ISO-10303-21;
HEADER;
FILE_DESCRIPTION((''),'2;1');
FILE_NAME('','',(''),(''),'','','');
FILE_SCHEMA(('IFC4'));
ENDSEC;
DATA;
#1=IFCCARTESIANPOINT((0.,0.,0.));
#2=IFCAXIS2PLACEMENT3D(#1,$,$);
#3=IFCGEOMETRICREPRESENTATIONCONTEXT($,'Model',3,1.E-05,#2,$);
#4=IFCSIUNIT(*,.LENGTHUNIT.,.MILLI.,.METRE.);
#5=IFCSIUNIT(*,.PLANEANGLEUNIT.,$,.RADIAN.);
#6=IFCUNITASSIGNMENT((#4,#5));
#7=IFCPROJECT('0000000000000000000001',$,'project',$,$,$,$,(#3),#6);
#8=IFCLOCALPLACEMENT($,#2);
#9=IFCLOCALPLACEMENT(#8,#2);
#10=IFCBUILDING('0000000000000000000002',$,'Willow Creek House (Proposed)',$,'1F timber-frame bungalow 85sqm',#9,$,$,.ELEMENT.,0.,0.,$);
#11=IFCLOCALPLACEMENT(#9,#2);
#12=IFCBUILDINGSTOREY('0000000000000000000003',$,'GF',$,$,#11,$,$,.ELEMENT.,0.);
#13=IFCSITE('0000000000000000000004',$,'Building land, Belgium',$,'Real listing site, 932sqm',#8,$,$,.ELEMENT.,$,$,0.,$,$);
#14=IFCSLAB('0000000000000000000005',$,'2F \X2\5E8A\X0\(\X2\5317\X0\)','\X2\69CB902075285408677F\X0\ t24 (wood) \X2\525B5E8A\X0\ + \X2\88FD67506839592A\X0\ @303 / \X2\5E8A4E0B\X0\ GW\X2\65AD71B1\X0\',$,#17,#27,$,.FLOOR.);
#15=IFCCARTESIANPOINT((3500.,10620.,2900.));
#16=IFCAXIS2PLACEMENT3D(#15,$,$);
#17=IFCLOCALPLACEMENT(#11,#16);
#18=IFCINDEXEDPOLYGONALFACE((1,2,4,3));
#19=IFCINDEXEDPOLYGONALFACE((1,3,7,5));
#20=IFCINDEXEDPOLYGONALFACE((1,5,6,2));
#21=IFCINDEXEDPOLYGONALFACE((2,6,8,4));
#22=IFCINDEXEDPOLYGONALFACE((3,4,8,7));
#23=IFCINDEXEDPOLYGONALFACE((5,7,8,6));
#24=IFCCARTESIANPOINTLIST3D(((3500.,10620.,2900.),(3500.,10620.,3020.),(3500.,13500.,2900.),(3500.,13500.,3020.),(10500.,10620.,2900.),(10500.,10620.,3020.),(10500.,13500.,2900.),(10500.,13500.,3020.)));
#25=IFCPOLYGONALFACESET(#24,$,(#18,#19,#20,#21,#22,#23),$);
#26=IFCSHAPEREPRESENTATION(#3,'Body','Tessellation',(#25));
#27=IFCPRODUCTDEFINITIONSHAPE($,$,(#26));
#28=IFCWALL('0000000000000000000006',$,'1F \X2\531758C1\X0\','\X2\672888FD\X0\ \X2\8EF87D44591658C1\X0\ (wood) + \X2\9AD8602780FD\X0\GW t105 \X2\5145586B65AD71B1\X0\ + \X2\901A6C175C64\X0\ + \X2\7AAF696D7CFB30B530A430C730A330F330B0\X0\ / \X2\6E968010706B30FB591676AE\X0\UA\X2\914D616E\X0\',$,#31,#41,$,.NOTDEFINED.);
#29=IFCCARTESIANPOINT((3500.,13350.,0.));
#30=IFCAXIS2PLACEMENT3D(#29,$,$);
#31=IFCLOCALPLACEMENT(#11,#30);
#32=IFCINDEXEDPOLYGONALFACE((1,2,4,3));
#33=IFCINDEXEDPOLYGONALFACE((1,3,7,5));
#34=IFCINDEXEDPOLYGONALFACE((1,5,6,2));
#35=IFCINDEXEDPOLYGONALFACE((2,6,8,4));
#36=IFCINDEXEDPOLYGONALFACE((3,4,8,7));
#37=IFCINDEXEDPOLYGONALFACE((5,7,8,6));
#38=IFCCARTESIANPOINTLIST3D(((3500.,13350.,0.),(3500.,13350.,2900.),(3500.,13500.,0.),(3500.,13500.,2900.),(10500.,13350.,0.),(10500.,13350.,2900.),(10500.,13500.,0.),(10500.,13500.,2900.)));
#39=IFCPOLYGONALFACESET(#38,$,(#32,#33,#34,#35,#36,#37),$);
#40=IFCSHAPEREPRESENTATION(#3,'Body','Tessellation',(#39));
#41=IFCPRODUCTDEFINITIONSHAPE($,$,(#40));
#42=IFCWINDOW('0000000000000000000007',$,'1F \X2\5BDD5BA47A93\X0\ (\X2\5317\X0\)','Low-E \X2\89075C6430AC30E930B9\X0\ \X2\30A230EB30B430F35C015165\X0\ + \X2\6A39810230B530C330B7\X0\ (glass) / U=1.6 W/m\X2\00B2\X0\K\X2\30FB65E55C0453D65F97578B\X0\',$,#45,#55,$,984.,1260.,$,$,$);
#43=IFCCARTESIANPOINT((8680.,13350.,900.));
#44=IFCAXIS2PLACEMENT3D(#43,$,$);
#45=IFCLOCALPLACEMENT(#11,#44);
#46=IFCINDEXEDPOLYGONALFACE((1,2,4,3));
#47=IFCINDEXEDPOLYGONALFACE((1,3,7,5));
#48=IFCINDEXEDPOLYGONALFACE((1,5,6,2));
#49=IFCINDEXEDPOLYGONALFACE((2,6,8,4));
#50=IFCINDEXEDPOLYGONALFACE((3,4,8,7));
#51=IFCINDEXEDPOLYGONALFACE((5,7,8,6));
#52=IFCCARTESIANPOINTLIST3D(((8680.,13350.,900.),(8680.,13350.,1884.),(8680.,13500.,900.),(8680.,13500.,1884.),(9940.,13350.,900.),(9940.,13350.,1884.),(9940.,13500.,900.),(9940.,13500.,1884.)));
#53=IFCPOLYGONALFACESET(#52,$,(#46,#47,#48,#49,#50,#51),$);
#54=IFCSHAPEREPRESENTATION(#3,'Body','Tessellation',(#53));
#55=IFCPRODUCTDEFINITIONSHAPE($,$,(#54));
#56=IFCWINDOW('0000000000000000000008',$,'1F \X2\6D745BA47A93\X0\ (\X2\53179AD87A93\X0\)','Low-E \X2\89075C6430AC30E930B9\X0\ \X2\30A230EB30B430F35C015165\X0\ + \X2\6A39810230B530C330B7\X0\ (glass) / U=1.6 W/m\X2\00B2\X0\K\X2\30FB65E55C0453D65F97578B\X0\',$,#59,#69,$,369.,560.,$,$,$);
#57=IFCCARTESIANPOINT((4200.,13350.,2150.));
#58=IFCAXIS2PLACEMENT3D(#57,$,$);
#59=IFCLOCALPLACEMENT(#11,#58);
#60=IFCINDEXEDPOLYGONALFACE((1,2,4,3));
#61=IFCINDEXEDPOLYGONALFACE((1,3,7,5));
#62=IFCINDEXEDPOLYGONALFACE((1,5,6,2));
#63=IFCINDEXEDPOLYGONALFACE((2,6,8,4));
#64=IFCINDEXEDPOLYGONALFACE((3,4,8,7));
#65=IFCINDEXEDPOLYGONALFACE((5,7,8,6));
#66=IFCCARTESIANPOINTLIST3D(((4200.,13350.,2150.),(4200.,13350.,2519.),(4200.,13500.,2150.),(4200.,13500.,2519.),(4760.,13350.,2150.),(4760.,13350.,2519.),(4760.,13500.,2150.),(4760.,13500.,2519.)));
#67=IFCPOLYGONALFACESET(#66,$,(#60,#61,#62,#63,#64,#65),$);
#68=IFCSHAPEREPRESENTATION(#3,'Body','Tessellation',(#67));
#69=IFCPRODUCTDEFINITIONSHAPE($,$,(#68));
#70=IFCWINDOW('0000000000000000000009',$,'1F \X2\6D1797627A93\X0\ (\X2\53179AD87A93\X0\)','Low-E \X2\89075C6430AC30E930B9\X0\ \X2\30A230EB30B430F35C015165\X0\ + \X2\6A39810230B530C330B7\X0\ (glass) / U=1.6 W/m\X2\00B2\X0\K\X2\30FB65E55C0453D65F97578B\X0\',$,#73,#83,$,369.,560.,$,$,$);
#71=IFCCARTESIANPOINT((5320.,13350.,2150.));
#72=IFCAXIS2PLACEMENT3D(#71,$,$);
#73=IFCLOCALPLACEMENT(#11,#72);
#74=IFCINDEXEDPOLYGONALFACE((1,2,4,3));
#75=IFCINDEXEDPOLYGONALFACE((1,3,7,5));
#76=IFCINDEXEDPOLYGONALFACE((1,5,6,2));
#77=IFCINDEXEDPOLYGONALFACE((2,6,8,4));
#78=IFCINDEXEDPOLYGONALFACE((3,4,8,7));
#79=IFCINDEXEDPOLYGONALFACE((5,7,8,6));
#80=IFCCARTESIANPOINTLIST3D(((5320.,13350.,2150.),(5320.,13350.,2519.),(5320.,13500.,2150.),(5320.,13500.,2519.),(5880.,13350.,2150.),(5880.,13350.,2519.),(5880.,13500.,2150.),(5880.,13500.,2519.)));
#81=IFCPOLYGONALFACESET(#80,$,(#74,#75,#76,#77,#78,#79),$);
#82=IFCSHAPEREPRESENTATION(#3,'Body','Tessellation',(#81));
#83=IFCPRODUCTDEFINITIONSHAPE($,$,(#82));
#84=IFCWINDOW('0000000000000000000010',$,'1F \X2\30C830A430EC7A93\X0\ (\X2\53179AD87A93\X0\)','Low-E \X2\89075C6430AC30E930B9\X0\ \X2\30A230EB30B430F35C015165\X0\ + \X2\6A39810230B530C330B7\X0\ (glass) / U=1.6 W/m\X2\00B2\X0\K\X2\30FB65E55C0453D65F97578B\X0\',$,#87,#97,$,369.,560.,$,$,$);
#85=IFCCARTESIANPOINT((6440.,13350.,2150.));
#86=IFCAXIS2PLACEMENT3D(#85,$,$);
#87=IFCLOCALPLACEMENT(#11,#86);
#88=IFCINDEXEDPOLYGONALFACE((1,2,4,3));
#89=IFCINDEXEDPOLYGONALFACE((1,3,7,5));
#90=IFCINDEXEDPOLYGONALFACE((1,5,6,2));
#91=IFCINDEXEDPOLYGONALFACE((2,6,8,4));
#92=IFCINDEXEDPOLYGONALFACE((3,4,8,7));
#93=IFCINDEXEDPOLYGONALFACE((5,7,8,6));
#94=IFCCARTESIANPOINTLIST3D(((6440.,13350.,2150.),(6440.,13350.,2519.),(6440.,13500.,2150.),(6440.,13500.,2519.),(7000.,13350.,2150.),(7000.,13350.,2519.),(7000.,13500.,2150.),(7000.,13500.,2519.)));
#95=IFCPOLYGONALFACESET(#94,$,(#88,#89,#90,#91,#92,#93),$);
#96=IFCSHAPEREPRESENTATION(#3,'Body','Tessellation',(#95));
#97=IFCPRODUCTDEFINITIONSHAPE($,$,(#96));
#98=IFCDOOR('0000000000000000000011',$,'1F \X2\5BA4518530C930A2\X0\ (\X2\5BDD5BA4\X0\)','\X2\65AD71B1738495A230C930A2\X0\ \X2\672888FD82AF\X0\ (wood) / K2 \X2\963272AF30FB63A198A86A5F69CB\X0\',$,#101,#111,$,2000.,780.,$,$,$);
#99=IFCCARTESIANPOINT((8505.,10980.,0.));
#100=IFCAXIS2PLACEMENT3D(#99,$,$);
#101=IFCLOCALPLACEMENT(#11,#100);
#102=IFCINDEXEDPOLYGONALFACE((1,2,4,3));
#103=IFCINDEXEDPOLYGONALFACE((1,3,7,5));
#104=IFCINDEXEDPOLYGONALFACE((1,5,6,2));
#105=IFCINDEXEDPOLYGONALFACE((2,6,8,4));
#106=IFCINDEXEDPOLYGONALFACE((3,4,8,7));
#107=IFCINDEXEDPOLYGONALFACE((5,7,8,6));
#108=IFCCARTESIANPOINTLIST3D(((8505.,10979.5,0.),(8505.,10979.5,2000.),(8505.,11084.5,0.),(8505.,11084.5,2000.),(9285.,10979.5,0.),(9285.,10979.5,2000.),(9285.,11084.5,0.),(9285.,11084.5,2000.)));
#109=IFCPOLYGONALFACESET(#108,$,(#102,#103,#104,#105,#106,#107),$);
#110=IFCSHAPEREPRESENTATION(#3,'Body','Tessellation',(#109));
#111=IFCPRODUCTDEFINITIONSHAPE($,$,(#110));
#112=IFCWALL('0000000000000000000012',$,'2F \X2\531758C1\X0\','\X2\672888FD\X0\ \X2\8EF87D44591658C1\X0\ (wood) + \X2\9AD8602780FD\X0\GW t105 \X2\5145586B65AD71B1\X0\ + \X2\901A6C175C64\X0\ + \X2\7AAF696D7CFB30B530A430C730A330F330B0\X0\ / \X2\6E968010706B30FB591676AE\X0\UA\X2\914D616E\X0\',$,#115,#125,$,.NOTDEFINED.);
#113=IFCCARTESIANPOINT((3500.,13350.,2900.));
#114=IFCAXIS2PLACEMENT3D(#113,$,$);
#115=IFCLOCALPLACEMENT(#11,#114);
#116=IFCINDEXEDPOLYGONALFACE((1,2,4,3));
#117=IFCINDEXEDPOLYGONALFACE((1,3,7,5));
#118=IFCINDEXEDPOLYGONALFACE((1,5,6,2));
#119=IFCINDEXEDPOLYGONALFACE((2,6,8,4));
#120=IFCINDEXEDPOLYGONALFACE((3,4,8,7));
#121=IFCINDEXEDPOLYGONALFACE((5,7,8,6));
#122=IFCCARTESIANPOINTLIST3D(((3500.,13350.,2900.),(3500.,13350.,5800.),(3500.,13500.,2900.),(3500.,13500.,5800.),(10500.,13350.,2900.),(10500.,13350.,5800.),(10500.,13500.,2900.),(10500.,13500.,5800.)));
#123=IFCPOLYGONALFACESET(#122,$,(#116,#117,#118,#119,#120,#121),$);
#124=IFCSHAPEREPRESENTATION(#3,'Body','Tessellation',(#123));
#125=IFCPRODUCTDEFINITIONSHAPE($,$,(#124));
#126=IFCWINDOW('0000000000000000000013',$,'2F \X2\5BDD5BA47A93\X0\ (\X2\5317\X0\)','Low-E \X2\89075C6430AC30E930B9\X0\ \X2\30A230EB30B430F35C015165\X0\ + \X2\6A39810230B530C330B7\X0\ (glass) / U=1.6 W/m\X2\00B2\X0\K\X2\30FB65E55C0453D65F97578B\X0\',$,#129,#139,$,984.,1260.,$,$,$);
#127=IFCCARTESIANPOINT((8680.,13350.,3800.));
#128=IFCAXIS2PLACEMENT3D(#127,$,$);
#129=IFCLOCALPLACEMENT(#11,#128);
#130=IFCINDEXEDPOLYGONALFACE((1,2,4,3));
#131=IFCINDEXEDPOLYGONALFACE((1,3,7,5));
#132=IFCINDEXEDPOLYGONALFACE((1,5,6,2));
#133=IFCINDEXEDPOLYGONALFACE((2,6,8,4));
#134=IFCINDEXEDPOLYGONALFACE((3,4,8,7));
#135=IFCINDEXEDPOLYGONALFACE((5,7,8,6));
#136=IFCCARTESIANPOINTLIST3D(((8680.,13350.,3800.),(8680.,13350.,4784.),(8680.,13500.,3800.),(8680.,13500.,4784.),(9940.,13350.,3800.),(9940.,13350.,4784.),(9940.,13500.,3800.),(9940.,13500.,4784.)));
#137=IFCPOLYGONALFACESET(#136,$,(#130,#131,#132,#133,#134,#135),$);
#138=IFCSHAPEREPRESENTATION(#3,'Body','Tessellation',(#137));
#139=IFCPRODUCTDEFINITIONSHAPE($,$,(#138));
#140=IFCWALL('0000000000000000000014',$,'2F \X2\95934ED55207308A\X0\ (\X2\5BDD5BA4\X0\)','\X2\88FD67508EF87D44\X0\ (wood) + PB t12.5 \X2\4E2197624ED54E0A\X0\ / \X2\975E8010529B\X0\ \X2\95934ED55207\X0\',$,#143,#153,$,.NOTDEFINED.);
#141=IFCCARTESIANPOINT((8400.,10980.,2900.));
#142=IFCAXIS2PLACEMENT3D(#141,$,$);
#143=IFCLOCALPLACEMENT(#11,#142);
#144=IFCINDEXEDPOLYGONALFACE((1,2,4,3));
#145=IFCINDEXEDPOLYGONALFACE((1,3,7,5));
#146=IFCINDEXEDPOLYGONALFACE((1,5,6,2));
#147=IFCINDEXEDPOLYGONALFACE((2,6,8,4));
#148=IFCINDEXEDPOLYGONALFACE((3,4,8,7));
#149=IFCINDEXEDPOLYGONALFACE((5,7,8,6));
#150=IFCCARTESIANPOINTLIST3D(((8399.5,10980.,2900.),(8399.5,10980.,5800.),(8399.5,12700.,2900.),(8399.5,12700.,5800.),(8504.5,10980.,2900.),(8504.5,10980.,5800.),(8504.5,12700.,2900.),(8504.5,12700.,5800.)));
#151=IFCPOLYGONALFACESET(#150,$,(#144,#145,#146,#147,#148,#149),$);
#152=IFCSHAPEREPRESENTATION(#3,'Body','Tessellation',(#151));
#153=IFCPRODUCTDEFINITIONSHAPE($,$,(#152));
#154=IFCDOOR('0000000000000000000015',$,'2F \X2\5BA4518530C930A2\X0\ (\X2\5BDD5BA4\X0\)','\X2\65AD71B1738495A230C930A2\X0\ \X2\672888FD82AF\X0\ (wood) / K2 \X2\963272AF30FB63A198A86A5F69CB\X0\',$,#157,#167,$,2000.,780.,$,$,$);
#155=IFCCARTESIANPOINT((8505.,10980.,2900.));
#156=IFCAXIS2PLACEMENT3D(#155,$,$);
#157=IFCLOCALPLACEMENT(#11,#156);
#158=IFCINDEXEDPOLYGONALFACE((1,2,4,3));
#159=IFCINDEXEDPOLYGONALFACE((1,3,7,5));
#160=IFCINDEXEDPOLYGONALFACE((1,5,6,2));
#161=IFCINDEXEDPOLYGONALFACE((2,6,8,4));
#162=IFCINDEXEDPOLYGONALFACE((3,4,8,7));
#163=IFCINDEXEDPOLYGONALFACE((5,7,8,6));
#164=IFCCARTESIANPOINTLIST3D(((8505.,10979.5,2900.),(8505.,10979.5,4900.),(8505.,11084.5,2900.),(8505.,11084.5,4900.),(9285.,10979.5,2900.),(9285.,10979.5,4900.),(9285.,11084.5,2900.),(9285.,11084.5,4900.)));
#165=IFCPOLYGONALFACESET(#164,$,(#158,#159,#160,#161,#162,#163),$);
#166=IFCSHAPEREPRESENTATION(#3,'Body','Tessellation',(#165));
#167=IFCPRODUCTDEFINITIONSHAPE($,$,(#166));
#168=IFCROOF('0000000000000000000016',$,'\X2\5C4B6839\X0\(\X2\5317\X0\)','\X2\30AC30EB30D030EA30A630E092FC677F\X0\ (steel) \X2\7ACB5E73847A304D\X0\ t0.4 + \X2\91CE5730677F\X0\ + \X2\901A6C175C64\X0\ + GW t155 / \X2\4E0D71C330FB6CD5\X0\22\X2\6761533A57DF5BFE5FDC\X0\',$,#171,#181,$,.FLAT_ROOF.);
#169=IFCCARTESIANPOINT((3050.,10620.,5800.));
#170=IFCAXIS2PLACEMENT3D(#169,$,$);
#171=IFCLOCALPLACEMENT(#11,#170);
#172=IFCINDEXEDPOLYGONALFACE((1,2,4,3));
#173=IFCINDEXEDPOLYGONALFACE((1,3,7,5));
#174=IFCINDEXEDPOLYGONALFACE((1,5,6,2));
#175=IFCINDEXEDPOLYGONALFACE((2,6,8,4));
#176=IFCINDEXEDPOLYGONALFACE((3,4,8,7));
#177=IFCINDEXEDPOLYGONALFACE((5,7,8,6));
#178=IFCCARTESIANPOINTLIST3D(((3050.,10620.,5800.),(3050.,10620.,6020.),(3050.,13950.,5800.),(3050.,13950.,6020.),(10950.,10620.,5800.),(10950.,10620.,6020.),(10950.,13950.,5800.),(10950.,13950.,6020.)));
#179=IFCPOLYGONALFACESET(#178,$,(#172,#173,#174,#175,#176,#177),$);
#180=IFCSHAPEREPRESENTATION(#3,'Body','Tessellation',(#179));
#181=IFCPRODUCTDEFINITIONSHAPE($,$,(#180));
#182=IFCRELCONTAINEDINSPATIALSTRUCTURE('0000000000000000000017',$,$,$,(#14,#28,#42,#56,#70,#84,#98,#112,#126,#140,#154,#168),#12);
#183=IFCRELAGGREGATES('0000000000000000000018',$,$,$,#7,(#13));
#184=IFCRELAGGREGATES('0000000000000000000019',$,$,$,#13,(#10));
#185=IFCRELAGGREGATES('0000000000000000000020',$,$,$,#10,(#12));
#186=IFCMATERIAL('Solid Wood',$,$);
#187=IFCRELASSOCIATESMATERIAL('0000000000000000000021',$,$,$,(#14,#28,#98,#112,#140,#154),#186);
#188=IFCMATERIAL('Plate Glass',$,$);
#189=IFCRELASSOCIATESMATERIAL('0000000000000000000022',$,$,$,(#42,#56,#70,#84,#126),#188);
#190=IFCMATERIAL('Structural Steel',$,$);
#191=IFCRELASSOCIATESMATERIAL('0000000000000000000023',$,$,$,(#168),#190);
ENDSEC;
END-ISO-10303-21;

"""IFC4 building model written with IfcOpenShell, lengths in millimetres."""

from ifc_helpers import new_model, si_unit, frame, frame_2d, origin, place, context, project, spatial, rectangle, extrude, material, element, fill, save


model = new_model("IFC4")

# Units and contexts
model_context = context("Model", 3, precision=1e-05, world=origin())
ifc_project = project(units=[si_unit("LENGTHUNIT", "METRE", prefix="MILLI"), si_unit("PLANEANGLEUNIT", "RADIAN")], contexts=[model_context])

# Site, building, storey
site_placement = place(None, origin())
site = spatial("IfcSite", under=ifc_project, at=site_placement, Name="Building land, Belgium", ObjectType="Real listing site, 932sqm", CompositionType="ELEMENT", RefElevation=0.0)
building_placement = place(site_placement, origin())
building = spatial("IfcBuilding", under=site, at=building_placement, Name="Willow Creek House (Proposed)", ObjectType="1F timber-frame bungalow 85sqm", CompositionType="ELEMENT", ElevationOfRefHeight=0.0, ElevationOfTerrain=0.0)
storey_placement = place(building_placement, origin())
storey = spatial("IfcBuildingStorey", under=building, at=storey_placement, Name="GF", CompositionType="ELEMENT", Elevation=0.0)

# Slab
ifc_material_1 = material(Name="Solid Wood")
slab_placement = place(storey_placement, frame((3500.0, 10620.0, 2900.0)))
element("IfcSlab", 1, at=slab_placement, inside=storey, material=ifc_material_1, Name="2F 床(北)", Description="構造用合板 t24 (wood) 剛床 + 製材根太 @303 / 床下 GW断熱", PredefinedType="FLOOR", context=model_context, shape_type="SweptSolid", body=[
    extrude(rectangle(XDim=7000.0, YDim=2880.0, at=frame_2d((3500.0, 1440.0))), frame((3500.0, 10620.0, 2900.0)), (0.0, 0.0, 1.0), 120.0),
])

# Wall, openings, windows
wall_1_placement = place(storey_placement, frame((3500.0, 13350.0, 0.0)))
wall_1 = element("IfcWall", 2, at=wall_1_placement, inside=storey, material=ifc_material_1, Name="1F 北壁", Description="木製 軸組外壁 (wood) + 高性能GW t105 充填断熱 + 通気層 + 窯業系サイディング / 準耐火・外皮UA配慮", PredefinedType="NOTDEFINED", context=model_context, shape_type="SweptSolid", body=[
    extrude(rectangle(XDim=7000.0, YDim=150.0, at=frame_2d((3500.0, 75.0))), frame((3500.0, 13350.0, 0.0)), (0.0, 0.0, 1.0), 2900.0),
])
opening_1_placement = place(storey_placement, frame((8680.0, 13350.0, 900.0)))
opening_1 = element("IfcOpeningElement", 3, at=opening_1_placement, cuts=wall_1, PredefinedType="NOTDEFINED", context=model_context, shape_type="SweptSolid", body=[
    extrude(rectangle(XDim=1260.0, YDim=150.0, at=frame_2d((630.0, 75.0))), frame((8680.0, 13350.0, 900.0)), (0.0, 0.0, 1.0), 984.0),
])
opening_2_placement = place(storey_placement, frame((4200.0, 13350.0, 2150.0)))
opening_2 = element("IfcOpeningElement", 4, at=opening_2_placement, cuts=wall_1, PredefinedType="NOTDEFINED", context=model_context, shape_type="SweptSolid", body=[
    extrude(rectangle(XDim=560.0, YDim=150.0, at=frame_2d((280.0, 75.0))), frame((4200.0, 13350.0, 2150.0)), (0.0, 0.0, 1.0), 369.0),
])
opening_3_placement = place(storey_placement, frame((5320.0, 13350.0, 2150.0)))
opening_3 = element("IfcOpeningElement", 5, at=opening_3_placement, cuts=wall_1, PredefinedType="NOTDEFINED", context=model_context, shape_type="SweptSolid", body=[
    extrude(rectangle(XDim=560.0, YDim=150.0, at=frame_2d((280.0, 75.0))), frame((5320.0, 13350.0, 2150.0)), (0.0, 0.0, 1.0), 369.0),
])
opening_4_placement = place(storey_placement, frame((6440.0, 13350.0, 2150.0)))
opening_4 = element("IfcOpeningElement", 6, at=opening_4_placement, cuts=wall_1, PredefinedType="NOTDEFINED", context=model_context, shape_type="SweptSolid", body=[
    extrude(rectangle(XDim=560.0, YDim=150.0, at=frame_2d((280.0, 75.0))), frame((6440.0, 13350.0, 2150.0)), (0.0, 0.0, 1.0), 369.0),
])
ifc_material_2 = material(Name="Plate Glass")
window_1_placement = place(storey_placement, frame((8680.0, 13350.0, 900.0)))
window_1 = element("IfcWindow", 7, at=window_1_placement, inside=storey, material=ifc_material_2, Name="1F 寝室窓 (北)", Description="Low-E 複層ガラス アルゴン封入 + 樹脂サッシ (glass) / U=1.6 W/m²K・日射取得型", OverallHeight=984.0, OverallWidth=1260.0, context=model_context, shape_type="SweptSolid", body=[
    extrude(rectangle(XDim=1260.0, YDim=150.0, at=frame_2d((630.0, 75.0))), frame((8680.0, 13350.0, 900.0)), (0.0, 0.0, 1.0), 984.0),
])
fill(opening_1, window_1)
window_2_placement = place(storey_placement, frame((4200.0, 13350.0, 2150.0)))
window_2 = element("IfcWindow", 8, at=window_2_placement, inside=storey, material=ifc_material_2, Name="1F 浴室窓 (北高窓)", Description="Low-E 複層ガラス アルゴン封入 + 樹脂サッシ (glass) / U=1.6 W/m²K・日射取得型", OverallHeight=369.0, OverallWidth=560.0, context=model_context, shape_type="SweptSolid", body=[
    extrude(rectangle(XDim=560.0, YDim=150.0, at=frame_2d((280.0, 75.0))), frame((4200.0, 13350.0, 2150.0)), (0.0, 0.0, 1.0), 369.0),
])
fill(opening_2, window_2)
window_3_placement = place(storey_placement, frame((5320.0, 13350.0, 2150.0)))
window_3 = element("IfcWindow", 9, at=window_3_placement, inside=storey, material=ifc_material_2, Name="1F 洗面窓 (北高窓)", Description="Low-E 複層ガラス アルゴン封入 + 樹脂サッシ (glass) / U=1.6 W/m²K・日射取得型", OverallHeight=369.0, OverallWidth=560.0, context=model_context, shape_type="SweptSolid", body=[
    extrude(rectangle(XDim=560.0, YDim=150.0, at=frame_2d((280.0, 75.0))), frame((5320.0, 13350.0, 2150.0)), (0.0, 0.0, 1.0), 369.0),
])
fill(opening_3, window_3)
window_4_placement = place(storey_placement, frame((6440.0, 13350.0, 2150.0)))
window_4 = element("IfcWindow", 10, at=window_4_placement, inside=storey, material=ifc_material_2, Name="1F トイレ窓 (北高窓)", Description="Low-E 複層ガラス アルゴン封入 + 樹脂サッシ (glass) / U=1.6 W/m²K・日射取得型", OverallHeight=369.0, OverallWidth=560.0, context=model_context, shape_type="SweptSolid", body=[
    extrude(rectangle(XDim=560.0, YDim=150.0, at=frame_2d((280.0, 75.0))), frame((6440.0, 13350.0, 2150.0)), (0.0, 0.0, 1.0), 369.0),
])
fill(opening_4, window_4)

# Door
door_1_placement = place(storey_placement, frame((8505.0, 10980.0, 0.0)))
element("IfcDoor", 11, at=door_1_placement, inside=storey, material=ifc_material_1, Name="1F 室内ドア (寝室)", Description="断熱玄関ドア 木製芯 (wood) / K2 防犯・採風機構", OverallHeight=2000.0, OverallWidth=780.0, context=model_context, shape_type="SweptSolid", body=[
    extrude(rectangle(XDim=780.0, YDim=105.0, at=frame_2d((390.0, 52.0))), frame((8505.0, 10980.0, 0.0)), (0.0, 0.0, 1.0), 2000.0),
])

# Wall, opening, window
wall_2_placement = place(storey_placement, frame((3500.0, 13350.0, 2900.0)))
wall_2 = element("IfcWall", 12, at=wall_2_placement, inside=storey, material=ifc_material_1, Name="2F 北壁", Description="木製 軸組外壁 (wood) + 高性能GW t105 充填断熱 + 通気層 + 窯業系サイディング / 準耐火・外皮UA配慮", PredefinedType="NOTDEFINED", context=model_context, shape_type="SweptSolid", body=[
    extrude(rectangle(XDim=7000.0, YDim=150.0, at=frame_2d((3500.0, 75.0))), frame((3500.0, 13350.0, 2900.0)), (0.0, 0.0, 1.0), 2900.0),
])
opening_5_placement = place(storey_placement, frame((8680.0, 13350.0, 3800.0)))
opening_5 = element("IfcOpeningElement", 13, at=opening_5_placement, cuts=wall_2, PredefinedType="NOTDEFINED", context=model_context, shape_type="SweptSolid", body=[
    extrude(rectangle(XDim=1260.0, YDim=150.0, at=frame_2d((630.0, 75.0))), frame((8680.0, 13350.0, 3800.0)), (0.0, 0.0, 1.0), 984.0),
])
window_5_placement = place(storey_placement, frame((8680.0, 13350.0, 3800.0)))
window_5 = element("IfcWindow", 14, at=window_5_placement, inside=storey, material=ifc_material_2, Name="2F 寝室窓 (北)", Description="Low-E 複層ガラス アルゴン封入 + 樹脂サッシ (glass) / U=1.6 W/m²K・日射取得型", OverallHeight=984.0, OverallWidth=1260.0, context=model_context, shape_type="SweptSolid", body=[
    extrude(rectangle(XDim=1260.0, YDim=150.0, at=frame_2d((630.0, 75.0))), frame((8680.0, 13350.0, 3800.0)), (0.0, 0.0, 1.0), 984.0),
])
fill(opening_5, window_5)

# Wall
wall_3_placement = place(storey_placement, frame((8400.0, 10980.0, 2900.0)))
element("IfcWall", 15, at=wall_3_placement, inside=storey, material=ifc_material_1, Name="2F 間仕切り (寝室)", Description="製材軸組 (wood) + PB t12.5 両面仕上 / 非耐力 間仕切", PredefinedType="NOTDEFINED", context=model_context, shape_type="SweptSolid", body=[
    extrude(rectangle(XDim=105.0, YDim=1720.0, at=frame_2d((52.0, 860.0))), frame((8400.0, 10980.0, 2900.0)), (0.0, 0.0, 1.0), 2900.0),
])

# Door
door_2_placement = place(storey_placement, frame((8505.0, 10980.0, 2900.0)))
element("IfcDoor", 16, at=door_2_placement, inside=storey, material=ifc_material_1, Name="2F 室内ドア (寝室)", Description="断熱玄関ドア 木製芯 (wood) / K2 防犯・採風機構", OverallHeight=2000.0, OverallWidth=780.0, context=model_context, shape_type="SweptSolid", body=[
    extrude(rectangle(XDim=780.0, YDim=105.0, at=frame_2d((390.0, 52.0))), frame((8505.0, 10980.0, 2900.0)), (0.0, 0.0, 1.0), 2000.0),
])

# Roof
ifc_material_3 = material(Name="Structural Steel")
roof_placement = place(storey_placement, frame((3050.0, 10620.0, 5800.0)))
element("IfcRoof", 17, at=roof_placement, inside=storey, material=ifc_material_3, Name="屋根(北)", Description="ガルバリウム鋼板 (steel) 立平葺き t0.4 + 野地板 + 通気層 + GW t155 / 不燃・法22条区域対応", PredefinedType="FLAT_ROOF", context=model_context, shape_type="SweptSolid", body=[
    extrude(rectangle(XDim=7900.0, YDim=3330.0, at=frame_2d((3950.0, 1665.0))), frame((3050.0, 10620.0, 5800.0)), (0.0, 0.0, 1.0), 220.0),
])

save(model, "model.ifc")
